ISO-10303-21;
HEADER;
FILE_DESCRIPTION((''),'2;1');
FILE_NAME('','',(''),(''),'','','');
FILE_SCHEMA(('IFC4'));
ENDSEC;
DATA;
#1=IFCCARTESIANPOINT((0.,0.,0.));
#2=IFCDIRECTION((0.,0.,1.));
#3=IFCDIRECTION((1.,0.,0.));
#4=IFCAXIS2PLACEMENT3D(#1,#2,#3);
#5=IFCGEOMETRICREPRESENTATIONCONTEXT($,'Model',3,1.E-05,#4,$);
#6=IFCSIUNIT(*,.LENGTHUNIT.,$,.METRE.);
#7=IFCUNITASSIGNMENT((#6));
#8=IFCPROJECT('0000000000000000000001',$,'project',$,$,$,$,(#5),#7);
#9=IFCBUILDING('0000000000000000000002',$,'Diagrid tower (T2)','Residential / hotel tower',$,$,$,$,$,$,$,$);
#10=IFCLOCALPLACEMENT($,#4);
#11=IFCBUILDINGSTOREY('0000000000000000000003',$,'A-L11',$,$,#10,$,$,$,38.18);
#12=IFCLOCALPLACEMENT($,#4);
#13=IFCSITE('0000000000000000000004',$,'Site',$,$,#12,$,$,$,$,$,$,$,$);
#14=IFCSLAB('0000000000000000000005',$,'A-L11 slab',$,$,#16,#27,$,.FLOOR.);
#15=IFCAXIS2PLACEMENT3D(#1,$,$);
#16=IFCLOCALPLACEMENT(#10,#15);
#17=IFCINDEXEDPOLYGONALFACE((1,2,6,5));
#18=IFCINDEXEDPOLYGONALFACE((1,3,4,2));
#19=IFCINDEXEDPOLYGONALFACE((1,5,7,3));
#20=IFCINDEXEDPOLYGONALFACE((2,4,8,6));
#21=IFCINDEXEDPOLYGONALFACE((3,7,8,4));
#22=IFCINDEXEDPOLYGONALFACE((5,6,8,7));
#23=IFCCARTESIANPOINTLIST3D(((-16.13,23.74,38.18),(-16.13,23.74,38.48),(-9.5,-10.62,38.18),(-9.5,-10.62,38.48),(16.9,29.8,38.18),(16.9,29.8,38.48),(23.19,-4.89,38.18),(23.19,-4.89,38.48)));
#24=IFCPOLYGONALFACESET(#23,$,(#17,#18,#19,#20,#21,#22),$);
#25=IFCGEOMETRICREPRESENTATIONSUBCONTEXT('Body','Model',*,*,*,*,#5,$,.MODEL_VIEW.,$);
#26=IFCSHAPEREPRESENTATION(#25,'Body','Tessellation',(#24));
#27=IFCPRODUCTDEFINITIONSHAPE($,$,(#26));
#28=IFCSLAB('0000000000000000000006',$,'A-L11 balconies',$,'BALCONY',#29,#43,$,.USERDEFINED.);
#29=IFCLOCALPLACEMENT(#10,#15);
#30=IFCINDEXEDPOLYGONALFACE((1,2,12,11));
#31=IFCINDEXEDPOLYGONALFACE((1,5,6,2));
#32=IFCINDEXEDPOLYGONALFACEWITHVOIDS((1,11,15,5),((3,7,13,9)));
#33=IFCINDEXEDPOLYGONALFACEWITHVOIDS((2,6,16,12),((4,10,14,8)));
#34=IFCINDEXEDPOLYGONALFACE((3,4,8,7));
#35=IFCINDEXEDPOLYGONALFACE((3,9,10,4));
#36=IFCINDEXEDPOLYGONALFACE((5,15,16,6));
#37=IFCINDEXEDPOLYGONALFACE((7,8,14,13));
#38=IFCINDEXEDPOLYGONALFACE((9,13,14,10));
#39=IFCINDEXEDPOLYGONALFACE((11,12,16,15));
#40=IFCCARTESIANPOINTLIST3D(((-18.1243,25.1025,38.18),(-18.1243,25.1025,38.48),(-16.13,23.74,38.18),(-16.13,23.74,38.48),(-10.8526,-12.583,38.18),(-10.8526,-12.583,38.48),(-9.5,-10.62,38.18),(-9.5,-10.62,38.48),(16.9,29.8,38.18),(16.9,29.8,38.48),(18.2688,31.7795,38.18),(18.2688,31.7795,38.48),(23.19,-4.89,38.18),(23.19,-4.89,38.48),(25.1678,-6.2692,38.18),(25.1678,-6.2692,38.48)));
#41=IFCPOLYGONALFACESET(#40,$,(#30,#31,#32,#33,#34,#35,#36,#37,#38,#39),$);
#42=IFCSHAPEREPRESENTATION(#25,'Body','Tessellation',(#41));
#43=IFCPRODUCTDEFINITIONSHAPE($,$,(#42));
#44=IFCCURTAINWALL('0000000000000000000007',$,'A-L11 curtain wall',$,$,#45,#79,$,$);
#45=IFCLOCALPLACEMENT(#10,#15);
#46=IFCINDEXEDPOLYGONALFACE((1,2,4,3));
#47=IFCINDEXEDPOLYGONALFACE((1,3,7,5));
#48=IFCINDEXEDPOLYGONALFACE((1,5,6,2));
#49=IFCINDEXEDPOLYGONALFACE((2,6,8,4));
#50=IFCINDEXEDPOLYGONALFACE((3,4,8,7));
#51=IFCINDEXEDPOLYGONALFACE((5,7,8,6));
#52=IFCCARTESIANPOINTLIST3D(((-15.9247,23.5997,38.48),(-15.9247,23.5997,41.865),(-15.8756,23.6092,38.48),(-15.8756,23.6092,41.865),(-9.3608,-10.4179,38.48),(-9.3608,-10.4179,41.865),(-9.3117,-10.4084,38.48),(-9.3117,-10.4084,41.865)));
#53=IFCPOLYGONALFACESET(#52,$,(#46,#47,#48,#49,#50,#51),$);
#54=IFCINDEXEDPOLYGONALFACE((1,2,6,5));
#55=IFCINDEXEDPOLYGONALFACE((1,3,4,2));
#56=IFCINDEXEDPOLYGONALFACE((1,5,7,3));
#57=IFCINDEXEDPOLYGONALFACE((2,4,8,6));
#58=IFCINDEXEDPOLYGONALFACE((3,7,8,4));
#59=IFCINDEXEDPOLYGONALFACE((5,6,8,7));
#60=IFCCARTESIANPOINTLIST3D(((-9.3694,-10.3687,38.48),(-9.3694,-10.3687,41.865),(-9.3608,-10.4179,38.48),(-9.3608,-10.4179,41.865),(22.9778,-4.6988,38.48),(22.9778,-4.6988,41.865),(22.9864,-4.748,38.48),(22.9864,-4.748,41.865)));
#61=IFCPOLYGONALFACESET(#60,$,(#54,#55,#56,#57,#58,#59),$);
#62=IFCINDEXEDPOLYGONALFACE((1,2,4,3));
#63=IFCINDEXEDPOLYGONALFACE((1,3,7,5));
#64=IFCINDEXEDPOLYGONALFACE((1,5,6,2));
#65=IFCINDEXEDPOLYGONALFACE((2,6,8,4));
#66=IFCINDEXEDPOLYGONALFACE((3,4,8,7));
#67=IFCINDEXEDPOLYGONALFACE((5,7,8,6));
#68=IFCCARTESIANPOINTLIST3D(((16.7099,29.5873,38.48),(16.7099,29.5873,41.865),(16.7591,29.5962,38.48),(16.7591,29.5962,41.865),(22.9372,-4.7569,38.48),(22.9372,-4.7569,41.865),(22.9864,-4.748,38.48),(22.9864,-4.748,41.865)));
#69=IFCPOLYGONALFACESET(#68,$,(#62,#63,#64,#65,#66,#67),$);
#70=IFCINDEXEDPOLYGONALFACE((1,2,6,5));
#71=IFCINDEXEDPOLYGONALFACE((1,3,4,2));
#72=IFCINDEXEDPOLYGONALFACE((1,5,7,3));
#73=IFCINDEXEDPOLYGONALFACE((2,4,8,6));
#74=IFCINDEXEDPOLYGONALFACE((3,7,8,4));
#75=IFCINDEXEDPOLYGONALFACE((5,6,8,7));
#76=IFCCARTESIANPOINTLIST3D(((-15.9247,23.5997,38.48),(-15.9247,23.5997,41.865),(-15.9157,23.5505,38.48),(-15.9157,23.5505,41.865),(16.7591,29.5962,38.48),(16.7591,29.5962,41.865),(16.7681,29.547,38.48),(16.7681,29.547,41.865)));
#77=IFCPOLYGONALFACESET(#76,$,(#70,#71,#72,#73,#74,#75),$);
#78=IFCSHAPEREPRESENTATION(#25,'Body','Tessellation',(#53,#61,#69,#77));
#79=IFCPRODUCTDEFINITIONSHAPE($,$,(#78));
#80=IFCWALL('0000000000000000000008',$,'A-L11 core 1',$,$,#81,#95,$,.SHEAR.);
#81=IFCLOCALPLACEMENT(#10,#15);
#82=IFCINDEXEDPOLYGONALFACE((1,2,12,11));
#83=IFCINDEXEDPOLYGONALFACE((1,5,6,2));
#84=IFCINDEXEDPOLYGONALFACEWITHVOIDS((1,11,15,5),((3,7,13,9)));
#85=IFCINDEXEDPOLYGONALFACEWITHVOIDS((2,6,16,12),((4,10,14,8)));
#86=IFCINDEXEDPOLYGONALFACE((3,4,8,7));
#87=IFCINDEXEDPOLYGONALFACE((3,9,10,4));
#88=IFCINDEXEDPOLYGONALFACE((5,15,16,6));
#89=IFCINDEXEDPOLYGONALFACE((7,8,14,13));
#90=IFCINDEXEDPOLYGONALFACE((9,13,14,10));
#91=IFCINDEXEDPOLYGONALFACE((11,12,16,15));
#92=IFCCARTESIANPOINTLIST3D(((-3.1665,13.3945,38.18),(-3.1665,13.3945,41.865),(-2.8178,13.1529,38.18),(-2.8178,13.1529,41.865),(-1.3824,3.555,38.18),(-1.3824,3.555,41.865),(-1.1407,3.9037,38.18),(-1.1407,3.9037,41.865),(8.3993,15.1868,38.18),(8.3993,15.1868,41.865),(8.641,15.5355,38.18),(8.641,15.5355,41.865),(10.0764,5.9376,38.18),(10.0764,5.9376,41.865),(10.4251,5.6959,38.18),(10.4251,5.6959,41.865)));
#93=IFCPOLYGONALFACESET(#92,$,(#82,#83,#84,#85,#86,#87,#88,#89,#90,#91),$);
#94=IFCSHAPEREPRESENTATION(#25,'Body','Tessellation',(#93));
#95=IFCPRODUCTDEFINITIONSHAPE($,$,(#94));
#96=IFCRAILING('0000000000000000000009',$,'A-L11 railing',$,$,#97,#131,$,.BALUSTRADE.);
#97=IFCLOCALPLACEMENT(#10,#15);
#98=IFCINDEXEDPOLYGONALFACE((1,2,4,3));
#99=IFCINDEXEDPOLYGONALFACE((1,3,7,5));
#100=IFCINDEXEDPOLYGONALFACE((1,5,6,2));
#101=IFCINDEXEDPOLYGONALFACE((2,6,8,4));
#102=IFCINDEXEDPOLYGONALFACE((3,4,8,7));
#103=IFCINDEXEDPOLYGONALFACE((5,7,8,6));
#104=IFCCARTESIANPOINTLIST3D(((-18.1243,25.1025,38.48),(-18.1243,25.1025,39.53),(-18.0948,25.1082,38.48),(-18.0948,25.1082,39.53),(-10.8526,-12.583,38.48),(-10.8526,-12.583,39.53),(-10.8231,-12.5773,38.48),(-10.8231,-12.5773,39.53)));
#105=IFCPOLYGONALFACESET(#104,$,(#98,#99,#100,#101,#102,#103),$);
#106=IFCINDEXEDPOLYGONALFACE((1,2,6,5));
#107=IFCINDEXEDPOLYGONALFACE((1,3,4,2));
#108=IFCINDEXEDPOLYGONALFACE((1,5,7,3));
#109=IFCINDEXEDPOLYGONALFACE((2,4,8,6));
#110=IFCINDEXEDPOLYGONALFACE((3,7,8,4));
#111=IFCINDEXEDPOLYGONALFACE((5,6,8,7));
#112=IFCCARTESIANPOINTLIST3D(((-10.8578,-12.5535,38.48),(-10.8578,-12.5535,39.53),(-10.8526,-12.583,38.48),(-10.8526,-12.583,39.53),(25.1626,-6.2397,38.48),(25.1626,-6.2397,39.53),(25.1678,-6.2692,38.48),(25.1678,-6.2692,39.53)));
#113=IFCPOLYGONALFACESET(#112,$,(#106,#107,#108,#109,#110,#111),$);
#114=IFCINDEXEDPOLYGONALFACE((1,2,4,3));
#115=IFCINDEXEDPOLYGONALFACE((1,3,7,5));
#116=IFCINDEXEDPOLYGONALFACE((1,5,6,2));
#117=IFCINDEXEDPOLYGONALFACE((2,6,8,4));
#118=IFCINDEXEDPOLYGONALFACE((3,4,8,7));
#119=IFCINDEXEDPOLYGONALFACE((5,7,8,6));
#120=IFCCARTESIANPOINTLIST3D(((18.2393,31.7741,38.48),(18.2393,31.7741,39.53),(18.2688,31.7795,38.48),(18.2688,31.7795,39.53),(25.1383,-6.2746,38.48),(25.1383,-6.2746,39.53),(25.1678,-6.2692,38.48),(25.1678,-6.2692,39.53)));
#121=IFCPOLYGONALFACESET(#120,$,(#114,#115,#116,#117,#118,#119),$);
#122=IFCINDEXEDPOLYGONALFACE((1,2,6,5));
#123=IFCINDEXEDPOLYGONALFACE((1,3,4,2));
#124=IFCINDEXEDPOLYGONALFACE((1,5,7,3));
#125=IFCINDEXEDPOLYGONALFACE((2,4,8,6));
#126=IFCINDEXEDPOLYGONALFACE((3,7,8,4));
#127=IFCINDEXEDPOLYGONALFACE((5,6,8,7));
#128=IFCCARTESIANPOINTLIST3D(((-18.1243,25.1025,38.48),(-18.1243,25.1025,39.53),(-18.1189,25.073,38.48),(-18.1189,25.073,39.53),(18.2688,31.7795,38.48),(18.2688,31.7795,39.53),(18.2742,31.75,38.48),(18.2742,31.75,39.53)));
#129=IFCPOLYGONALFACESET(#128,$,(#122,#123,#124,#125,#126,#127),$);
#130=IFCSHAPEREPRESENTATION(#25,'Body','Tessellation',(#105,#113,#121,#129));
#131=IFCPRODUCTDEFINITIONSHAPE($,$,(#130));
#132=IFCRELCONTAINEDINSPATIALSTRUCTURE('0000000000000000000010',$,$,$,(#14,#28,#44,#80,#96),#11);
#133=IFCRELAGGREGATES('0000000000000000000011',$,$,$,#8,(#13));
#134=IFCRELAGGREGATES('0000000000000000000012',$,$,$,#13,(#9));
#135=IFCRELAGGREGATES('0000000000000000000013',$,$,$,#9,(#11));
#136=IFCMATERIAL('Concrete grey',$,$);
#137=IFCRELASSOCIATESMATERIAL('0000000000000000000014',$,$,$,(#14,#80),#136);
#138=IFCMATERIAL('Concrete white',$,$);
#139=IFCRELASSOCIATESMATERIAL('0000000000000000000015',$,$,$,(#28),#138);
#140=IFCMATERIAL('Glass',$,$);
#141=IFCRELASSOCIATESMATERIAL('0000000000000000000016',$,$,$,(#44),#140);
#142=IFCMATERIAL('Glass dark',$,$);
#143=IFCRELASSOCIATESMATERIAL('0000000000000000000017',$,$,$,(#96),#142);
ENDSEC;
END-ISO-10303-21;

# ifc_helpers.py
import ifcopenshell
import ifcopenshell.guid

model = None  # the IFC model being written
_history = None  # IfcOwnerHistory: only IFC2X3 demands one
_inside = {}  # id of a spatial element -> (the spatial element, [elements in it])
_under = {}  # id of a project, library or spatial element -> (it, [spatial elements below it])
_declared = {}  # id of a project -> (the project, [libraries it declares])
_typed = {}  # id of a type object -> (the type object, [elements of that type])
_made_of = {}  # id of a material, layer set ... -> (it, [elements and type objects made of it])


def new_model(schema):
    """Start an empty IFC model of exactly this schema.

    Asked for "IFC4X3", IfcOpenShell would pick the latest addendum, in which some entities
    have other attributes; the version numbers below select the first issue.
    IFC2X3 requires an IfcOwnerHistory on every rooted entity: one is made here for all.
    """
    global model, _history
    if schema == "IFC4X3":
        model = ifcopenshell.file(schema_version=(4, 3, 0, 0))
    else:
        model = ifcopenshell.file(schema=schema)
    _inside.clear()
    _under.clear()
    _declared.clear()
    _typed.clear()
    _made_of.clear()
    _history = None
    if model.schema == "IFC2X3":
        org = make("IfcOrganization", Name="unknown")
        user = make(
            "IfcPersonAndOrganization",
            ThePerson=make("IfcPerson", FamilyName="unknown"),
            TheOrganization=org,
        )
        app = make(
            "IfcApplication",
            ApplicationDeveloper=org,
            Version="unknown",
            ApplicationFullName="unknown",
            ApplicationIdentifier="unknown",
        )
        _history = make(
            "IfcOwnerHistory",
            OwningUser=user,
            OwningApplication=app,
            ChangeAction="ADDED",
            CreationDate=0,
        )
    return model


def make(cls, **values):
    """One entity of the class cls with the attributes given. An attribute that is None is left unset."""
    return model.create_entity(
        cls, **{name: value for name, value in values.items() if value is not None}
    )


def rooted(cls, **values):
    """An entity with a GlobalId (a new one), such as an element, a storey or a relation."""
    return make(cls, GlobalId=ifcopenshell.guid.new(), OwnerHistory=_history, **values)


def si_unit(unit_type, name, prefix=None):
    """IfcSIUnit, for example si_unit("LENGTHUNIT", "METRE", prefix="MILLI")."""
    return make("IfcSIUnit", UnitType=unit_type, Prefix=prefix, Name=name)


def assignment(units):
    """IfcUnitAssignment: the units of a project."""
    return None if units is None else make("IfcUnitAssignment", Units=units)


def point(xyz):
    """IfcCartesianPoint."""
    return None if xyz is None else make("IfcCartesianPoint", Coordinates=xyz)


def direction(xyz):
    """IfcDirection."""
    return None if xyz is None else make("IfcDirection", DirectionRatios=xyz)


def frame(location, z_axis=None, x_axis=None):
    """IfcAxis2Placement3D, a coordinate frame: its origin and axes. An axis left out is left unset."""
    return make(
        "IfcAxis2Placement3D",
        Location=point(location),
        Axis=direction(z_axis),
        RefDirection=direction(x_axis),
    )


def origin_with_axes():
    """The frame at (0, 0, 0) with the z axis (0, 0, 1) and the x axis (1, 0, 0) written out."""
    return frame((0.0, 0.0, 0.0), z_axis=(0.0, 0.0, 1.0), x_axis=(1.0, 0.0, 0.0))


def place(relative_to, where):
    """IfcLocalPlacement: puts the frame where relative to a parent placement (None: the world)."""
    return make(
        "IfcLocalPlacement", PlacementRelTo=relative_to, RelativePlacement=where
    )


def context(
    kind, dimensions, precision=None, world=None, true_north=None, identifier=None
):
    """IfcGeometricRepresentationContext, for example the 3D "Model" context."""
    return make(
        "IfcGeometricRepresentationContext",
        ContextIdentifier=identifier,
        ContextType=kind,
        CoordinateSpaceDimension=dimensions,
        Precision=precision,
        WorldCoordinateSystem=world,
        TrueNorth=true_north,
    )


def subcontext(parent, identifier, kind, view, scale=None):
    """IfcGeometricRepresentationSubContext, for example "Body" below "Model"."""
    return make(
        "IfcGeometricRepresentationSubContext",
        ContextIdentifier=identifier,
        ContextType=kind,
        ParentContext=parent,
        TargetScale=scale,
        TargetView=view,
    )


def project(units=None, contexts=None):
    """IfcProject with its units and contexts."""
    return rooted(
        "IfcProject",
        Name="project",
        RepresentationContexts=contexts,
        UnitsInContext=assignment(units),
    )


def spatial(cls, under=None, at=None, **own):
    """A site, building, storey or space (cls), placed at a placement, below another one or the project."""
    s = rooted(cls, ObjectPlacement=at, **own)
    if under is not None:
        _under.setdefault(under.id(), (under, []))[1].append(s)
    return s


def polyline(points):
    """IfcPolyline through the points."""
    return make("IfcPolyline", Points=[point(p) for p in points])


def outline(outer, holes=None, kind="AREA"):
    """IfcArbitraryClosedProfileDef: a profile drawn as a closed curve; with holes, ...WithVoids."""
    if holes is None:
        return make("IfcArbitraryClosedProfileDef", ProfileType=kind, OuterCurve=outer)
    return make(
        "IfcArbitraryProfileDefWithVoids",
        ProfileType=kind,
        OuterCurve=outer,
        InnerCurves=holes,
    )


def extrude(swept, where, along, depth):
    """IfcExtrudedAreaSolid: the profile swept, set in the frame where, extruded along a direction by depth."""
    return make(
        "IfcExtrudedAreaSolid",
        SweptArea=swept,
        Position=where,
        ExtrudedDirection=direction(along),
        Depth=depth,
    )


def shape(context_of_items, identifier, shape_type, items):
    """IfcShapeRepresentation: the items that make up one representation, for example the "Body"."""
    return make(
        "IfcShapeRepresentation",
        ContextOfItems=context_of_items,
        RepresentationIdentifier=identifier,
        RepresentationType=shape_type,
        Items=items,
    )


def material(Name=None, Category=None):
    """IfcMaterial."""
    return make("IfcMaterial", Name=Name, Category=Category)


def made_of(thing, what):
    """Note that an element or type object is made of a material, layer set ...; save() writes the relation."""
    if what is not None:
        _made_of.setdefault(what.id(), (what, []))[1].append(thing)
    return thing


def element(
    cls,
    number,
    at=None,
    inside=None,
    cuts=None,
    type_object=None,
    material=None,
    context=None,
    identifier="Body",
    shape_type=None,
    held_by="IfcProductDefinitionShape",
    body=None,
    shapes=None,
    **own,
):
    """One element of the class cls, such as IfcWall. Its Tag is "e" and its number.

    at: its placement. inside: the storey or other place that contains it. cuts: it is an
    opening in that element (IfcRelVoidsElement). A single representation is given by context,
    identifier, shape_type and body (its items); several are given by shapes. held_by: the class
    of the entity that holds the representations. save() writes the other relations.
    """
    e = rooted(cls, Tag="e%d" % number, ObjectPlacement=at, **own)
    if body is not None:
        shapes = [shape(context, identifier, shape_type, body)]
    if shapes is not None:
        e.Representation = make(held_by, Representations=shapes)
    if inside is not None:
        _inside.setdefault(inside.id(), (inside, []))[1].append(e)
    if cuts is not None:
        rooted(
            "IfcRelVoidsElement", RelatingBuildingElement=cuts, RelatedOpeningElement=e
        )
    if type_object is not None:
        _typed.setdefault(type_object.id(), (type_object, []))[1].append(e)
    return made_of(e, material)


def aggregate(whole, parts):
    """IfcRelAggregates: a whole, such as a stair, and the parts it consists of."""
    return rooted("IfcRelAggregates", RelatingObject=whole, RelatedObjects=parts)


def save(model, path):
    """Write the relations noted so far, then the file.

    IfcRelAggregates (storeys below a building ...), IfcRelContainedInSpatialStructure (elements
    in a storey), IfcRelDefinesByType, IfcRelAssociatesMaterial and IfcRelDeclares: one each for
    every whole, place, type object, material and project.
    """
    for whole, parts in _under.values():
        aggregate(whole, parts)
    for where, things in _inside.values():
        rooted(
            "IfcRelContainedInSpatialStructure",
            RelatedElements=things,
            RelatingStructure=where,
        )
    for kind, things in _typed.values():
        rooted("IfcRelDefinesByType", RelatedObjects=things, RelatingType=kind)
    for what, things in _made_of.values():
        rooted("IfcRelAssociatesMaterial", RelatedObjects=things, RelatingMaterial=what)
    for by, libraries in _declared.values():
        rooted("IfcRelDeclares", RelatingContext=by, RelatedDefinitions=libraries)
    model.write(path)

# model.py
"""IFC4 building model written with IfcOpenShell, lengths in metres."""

from ifc_helpers import new_model, si_unit, frame, origin_with_axes, place, context, subcontext, project, spatial, polyline, outline, extrude, material, element, save


model = new_model("IFC4")

# Units and contexts
model_context = context("Model", 3, precision=1e-05, world=origin_with_axes())
body_context = subcontext(model_context, "Body", "Model", "MODEL_VIEW")
ifc_project = project(units=[si_unit("LENGTHUNIT", "METRE")], contexts=[model_context])

# Site, building, storey
site_placement = place(None, origin_with_axes())
site = spatial("IfcSite", under=ifc_project, at=site_placement, Name="Site")
building = spatial("IfcBuilding", under=site, Name="Diagrid tower (T2)", Description="Residential / hotel tower")
storey_placement = place(None, origin_with_axes())
storey = spatial("IfcBuildingStorey", under=building, at=storey_placement, Name="A-L11", Elevation=38.18)

# Slabs
ifc_material_1 = material(Name="Concrete grey")
slab_1_placement = place(storey_placement, origin_with_axes())
element("IfcSlab", 1, at=slab_1_placement, inside=storey, material=ifc_material_1, Name="A-L11 slab", PredefinedType="FLOOR", context=body_context, shape_type="SweptSolid", body=[
    extrude(outline(polyline([(-16.13, 23.74), (-9.5, -10.62), (23.19, -4.89), (16.9, 29.8), (-16.13, 23.74)])), frame((0.0, 0.0, 38.18), z_axis=(0.0, 0.0, 1.0), x_axis=(1.0, 0.0, 0.0)), (0.0, 0.0, 1.0), 0.3),
])
ifc_material_2 = material(Name="Concrete white")
slab_2_placement = place(storey_placement, origin_with_axes())
element("IfcSlab", 2, at=slab_2_placement, inside=storey, material=ifc_material_2, Name="A-L11 balconies", ObjectType="BALCONY", PredefinedType="USERDEFINED", context=body_context, shape_type="SweptSolid", body=[
    extrude(outline(polyline([(-18.1243, 25.1025), (-10.8526, -12.583), (25.1678, -6.2692), (18.2688, 31.7795), (-18.1243, 25.1025)]), holes=[polyline([(-16.13, 23.74), (-9.5, -10.62), (23.19, -4.89), (16.9, 29.8), (-16.13, 23.74)])]), frame((0.0, 0.0, 38.18), z_axis=(0.0, 0.0, 1.0), x_axis=(1.0, 0.0, 0.0)), (0.0, 0.0, 1.0), 0.3),
])

# Curtain wall
ifc_material_3 = material(Name="Glass")
curtain_wall_placement = place(storey_placement, origin_with_axes())
element("IfcCurtainWall", 3, at=curtain_wall_placement, inside=storey, material=ifc_material_3, Name="A-L11 curtain wall", context=body_context, shape_type="SweptSolid", body=[
    extrude(outline(polyline([(-15.9247, 23.5997), (-9.3608, -10.4179), (-9.3117, -10.4084), (-15.8756, 23.6092), (-15.9247, 23.5997)])), frame((0.0, 0.0, 38.48), z_axis=(0.0, 0.0, 1.0), x_axis=(1.0, 0.0, 0.0)), (0.0, 0.0, 1.0), 3.385),
    extrude(outline(polyline([(-9.3608, -10.4179), (22.9864, -4.748), (22.9778, -4.6988), (-9.3694, -10.3687), (-9.3608, -10.4179)])), frame((0.0, 0.0, 38.48), z_axis=(0.0, 0.0, 1.0), x_axis=(1.0, 0.0, 0.0)), (0.0, 0.0, 1.0), 3.385),
    extrude(outline(polyline([(22.9864, -4.748), (16.7591, 29.5962), (16.7099, 29.5873), (22.9372, -4.7569), (22.9864, -4.748)])), frame((0.0, 0.0, 38.48), z_axis=(0.0, 0.0, 1.0), x_axis=(1.0, 0.0, 0.0)), (0.0, 0.0, 1.0), 3.385),
    extrude(outline(polyline([(16.7591, 29.5962), (-15.9247, 23.5997), (-15.9157, 23.5505), (16.7681, 29.547), (16.7591, 29.5962)])), frame((0.0, 0.0, 38.48), z_axis=(0.0, 0.0, 1.0), x_axis=(1.0, 0.0, 0.0)), (0.0, 0.0, 1.0), 3.385),
])

# Wall
wall_placement = place(storey_placement, origin_with_axes())
element("IfcWall", 4, at=wall_placement, inside=storey, material=ifc_material_1, Name="A-L11 core 1", PredefinedType="SHEAR", context=body_context, shape_type="SweptSolid", body=[
    extrude(outline(polyline([(10.4251, 5.6959), (8.641, 15.5355), (-3.1665, 13.3945), (-1.3824, 3.555), (10.4251, 5.6959)]), holes=[polyline([(10.0764, 5.9376), (8.3993, 15.1868), (-2.8178, 13.1529), (-1.1407, 3.9037), (10.0764, 5.9376)])]), frame((0.0, 0.0, 38.18), z_axis=(0.0, 0.0, 1.0), x_axis=(1.0, 0.0, 0.0)), (0.0, 0.0, 1.0), 3.685),
])

# Railing
ifc_material_4 = material(Name="Glass dark")
railing_placement = place(storey_placement, origin_with_axes())
element("IfcRailing", 5, at=railing_placement, inside=storey, material=ifc_material_4, Name="A-L11 railing", PredefinedType="BALUSTRADE", context=body_context, shape_type="SweptSolid", body=[
    extrude(outline(polyline([(-18.1243, 25.1025), (-10.8526, -12.583), (-10.8231, -12.5773), (-18.0948, 25.1082), (-18.1243, 25.1025)])), frame((0.0, 0.0, 38.48), z_axis=(0.0, 0.0, 1.0), x_axis=(1.0, 0.0, 0.0)), (0.0, 0.0, 1.0), 1.05),
    extrude(outline(polyline([(-10.8526, -12.583), (25.1678, -6.2692), (25.1626, -6.2397), (-10.8578, -12.5535), (-10.8526, -12.583)])), frame((0.0, 0.0, 38.48), z_axis=(0.0, 0.0, 1.0), x_axis=(1.0, 0.0, 0.0)), (0.0, 0.0, 1.0), 1.05),
    extrude(outline(polyline([(25.1678, -6.2692), (18.2688, 31.7795), (18.2393, 31.7741), (25.1383, -6.2746), (25.1678, -6.2692)])), frame((0.0, 0.0, 38.48), z_axis=(0.0, 0.0, 1.0), x_axis=(1.0, 0.0, 0.0)), (0.0, 0.0, 1.0), 1.05),
    extrude(outline(polyline([(18.2688, 31.7795), (-18.1243, 25.1025), (-18.1189, 25.073), (18.2742, 31.75), (18.2688, 31.7795)])), frame((0.0, 0.0, 38.48), z_axis=(0.0, 0.0, 1.0), x_axis=(1.0, 0.0, 0.0)), (0.0, 0.0, 1.0), 1.05),
])

save(model, "model.ifc")
